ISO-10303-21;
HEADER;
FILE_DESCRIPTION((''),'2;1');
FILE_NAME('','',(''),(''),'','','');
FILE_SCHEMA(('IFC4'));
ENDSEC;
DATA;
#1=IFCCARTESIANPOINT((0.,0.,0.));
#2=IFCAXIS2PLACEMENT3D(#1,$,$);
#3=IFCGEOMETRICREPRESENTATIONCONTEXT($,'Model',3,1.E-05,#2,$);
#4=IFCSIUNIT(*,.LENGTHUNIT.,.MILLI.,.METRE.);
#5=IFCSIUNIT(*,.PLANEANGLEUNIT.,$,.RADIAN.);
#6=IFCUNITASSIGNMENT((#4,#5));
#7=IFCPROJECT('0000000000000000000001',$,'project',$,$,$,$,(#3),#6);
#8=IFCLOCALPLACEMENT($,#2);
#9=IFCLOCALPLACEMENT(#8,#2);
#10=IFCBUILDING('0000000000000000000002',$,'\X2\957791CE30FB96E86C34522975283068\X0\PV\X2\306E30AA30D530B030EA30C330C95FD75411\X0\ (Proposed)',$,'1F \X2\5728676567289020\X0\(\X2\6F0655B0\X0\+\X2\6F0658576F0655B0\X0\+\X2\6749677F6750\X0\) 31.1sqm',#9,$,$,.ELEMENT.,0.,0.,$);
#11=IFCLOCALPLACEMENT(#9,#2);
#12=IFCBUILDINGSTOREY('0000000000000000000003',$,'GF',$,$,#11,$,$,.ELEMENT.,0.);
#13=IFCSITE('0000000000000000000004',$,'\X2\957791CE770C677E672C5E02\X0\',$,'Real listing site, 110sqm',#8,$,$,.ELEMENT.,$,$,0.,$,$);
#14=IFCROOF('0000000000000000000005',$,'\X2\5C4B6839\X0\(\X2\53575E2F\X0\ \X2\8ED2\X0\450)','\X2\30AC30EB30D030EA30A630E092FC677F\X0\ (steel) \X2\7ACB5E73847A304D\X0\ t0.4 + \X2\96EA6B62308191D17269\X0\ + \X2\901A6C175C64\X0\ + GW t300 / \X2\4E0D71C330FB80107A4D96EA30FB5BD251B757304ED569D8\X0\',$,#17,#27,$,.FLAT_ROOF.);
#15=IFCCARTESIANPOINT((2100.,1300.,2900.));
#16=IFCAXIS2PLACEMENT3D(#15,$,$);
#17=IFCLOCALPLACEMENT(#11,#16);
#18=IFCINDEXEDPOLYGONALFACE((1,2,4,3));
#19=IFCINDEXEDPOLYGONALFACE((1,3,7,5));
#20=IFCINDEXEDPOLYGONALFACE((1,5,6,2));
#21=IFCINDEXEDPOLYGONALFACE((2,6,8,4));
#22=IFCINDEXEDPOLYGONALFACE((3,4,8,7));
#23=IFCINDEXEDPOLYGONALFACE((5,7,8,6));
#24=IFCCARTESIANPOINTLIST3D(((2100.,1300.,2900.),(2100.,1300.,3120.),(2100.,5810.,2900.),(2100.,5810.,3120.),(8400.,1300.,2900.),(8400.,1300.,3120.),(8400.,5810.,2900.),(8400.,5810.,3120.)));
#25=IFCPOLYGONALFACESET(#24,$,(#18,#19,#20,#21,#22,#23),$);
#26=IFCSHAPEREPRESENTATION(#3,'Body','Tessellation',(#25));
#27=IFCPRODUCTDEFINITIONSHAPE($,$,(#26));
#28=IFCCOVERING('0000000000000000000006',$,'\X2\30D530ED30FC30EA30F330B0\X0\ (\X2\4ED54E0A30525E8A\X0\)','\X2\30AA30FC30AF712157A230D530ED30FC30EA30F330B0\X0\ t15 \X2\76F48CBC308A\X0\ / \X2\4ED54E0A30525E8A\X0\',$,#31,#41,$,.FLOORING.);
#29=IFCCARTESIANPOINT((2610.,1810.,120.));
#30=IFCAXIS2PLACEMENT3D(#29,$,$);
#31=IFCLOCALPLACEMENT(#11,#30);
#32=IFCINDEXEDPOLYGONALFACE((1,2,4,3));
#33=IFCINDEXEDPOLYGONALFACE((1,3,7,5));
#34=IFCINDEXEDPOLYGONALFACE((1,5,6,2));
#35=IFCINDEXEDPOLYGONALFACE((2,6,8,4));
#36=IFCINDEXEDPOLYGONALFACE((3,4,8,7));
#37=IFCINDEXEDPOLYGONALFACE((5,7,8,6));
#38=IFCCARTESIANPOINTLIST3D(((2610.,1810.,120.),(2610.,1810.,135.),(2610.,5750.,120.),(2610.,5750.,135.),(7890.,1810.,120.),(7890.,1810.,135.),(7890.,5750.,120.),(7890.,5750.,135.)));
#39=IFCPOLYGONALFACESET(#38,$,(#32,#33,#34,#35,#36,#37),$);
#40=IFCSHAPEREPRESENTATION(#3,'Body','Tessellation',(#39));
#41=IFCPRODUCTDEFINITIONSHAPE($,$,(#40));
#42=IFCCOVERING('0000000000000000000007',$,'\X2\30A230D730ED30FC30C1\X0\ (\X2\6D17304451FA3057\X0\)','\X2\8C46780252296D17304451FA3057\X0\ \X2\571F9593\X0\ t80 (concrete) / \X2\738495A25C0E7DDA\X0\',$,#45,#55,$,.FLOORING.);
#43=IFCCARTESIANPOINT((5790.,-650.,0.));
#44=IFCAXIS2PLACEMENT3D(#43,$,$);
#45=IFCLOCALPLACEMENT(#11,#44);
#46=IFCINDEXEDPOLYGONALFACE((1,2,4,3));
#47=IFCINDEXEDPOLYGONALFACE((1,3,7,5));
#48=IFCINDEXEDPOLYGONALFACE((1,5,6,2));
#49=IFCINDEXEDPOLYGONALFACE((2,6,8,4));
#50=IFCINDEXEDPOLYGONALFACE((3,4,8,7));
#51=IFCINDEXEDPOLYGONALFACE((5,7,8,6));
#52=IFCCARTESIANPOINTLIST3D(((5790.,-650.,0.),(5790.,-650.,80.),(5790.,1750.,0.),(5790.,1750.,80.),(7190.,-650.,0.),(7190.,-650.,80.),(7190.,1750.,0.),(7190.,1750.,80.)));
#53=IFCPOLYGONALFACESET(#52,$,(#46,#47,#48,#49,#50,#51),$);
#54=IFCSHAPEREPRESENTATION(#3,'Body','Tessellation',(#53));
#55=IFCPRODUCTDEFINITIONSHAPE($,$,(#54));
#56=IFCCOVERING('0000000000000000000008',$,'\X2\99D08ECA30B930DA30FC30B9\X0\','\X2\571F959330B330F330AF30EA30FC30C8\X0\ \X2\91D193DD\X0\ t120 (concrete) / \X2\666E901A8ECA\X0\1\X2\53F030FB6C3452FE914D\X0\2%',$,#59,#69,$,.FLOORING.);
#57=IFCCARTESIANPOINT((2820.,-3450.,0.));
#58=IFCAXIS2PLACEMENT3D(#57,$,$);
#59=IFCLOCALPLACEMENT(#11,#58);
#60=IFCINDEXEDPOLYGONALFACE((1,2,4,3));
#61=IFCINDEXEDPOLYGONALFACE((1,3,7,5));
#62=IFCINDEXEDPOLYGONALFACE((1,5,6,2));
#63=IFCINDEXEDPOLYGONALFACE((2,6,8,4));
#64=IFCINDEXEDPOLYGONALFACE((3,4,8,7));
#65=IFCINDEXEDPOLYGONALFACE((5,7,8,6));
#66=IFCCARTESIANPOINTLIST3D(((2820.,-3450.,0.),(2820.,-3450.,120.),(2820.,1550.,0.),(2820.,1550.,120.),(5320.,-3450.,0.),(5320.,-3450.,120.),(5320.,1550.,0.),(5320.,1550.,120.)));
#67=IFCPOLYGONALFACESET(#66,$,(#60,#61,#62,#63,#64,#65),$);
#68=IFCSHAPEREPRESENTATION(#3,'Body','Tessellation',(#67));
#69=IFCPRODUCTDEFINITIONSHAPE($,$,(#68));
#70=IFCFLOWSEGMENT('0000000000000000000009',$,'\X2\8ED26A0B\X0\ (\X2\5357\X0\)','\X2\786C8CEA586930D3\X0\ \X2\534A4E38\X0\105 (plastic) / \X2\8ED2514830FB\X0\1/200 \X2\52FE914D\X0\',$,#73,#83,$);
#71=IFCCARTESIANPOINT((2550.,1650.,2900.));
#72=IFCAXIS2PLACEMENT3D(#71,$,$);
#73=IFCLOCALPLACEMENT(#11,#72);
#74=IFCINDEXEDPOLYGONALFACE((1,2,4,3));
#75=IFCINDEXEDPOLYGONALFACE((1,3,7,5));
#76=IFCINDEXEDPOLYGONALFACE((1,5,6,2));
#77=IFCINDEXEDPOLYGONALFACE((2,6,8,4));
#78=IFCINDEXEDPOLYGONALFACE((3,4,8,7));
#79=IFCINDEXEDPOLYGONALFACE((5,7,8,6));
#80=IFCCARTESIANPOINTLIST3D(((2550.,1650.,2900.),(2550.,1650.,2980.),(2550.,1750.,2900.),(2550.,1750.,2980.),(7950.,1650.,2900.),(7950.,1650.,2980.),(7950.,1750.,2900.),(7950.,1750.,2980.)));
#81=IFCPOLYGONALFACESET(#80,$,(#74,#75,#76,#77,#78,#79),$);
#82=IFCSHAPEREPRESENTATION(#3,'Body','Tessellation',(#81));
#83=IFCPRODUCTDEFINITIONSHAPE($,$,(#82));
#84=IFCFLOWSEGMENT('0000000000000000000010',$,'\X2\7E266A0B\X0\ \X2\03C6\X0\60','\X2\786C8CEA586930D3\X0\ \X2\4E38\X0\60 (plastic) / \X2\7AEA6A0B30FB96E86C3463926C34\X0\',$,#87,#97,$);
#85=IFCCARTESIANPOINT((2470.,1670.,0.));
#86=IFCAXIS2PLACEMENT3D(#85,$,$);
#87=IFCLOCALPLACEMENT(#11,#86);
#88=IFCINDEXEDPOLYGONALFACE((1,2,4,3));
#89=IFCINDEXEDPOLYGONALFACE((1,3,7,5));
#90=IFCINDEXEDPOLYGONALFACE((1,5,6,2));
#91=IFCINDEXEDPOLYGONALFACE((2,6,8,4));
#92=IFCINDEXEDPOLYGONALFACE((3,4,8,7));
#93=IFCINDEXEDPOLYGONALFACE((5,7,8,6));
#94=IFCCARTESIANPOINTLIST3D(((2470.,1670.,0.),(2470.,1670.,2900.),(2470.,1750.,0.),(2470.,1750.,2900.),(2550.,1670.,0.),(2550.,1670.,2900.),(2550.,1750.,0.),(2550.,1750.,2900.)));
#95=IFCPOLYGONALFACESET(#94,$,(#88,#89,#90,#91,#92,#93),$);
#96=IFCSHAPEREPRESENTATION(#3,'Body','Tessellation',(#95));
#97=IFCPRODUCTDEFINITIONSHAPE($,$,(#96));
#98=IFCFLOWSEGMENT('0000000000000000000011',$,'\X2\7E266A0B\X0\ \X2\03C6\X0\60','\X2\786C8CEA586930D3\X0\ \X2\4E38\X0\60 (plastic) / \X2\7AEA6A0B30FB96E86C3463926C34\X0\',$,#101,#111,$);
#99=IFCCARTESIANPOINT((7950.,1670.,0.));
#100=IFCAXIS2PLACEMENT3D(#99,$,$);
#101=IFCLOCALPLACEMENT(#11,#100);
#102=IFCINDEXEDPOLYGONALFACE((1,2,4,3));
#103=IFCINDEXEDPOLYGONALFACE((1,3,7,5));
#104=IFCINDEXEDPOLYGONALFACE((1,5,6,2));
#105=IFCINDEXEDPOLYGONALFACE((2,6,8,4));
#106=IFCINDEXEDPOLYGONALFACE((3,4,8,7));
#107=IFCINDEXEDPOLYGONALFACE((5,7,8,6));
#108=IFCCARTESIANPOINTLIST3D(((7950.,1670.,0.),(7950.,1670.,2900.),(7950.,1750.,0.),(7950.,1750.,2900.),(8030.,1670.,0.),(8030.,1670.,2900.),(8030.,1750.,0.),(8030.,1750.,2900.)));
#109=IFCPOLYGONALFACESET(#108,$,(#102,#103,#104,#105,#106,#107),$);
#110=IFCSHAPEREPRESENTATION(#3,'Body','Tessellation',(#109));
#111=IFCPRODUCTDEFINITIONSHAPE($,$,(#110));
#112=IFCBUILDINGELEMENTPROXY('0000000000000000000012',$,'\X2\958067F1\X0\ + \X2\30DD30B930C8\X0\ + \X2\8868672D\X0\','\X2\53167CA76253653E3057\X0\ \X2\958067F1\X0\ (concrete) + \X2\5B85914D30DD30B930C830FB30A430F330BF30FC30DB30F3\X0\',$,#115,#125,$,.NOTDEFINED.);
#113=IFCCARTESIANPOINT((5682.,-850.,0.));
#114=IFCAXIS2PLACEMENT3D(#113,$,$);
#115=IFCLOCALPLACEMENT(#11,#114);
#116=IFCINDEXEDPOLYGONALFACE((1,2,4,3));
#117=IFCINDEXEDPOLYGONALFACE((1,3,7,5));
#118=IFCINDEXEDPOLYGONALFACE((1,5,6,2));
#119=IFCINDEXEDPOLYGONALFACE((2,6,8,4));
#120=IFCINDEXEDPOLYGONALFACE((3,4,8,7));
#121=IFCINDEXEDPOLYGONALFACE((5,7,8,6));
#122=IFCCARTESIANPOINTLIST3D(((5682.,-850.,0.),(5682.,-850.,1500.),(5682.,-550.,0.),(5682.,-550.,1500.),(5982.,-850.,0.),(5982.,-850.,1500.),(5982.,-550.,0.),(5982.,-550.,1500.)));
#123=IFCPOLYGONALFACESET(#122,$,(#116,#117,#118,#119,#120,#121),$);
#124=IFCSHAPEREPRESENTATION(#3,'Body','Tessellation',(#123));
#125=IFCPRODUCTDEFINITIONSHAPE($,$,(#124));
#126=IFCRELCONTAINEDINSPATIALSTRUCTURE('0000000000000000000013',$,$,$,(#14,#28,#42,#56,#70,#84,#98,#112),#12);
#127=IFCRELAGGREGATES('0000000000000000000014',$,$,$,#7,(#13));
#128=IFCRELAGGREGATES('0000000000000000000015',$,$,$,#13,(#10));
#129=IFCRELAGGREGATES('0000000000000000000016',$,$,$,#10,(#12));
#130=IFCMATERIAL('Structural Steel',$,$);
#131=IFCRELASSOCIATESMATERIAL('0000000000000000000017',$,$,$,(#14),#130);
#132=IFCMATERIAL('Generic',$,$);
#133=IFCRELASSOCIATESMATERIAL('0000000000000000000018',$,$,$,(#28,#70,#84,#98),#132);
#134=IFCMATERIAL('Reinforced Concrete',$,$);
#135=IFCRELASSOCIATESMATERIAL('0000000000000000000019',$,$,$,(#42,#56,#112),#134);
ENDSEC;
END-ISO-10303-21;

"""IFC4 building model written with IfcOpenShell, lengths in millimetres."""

from ifc_helpers import new_model, si_unit, frame, frame_2d, origin, place, context, project, spatial, rectangle, extrude, material, element, save


model = new_model("IFC4")

# Units and contexts
model_context = context("Model", 3, precision=1e-05, world=origin())
ifc_project = project(units=[si_unit("LENGTHUNIT", "METRE", prefix="MILLI"), si_unit("PLANEANGLEUNIT", "RADIAN")], contexts=[model_context])

# Site, building, storey
site_placement = place(None, origin())
site = spatial("IfcSite", under=ifc_project, at=site_placement, Name="長野県松本市", ObjectType="Real listing site, 110sqm", CompositionType="ELEMENT", RefElevation=0.0)
building_placement = place(site_placement, origin())
building = spatial("IfcBuilding", under=site, at=building_placement, Name="長野・雨水利用とPVのオフグリッド志向 (Proposed)", ObjectType="1F 在来木造(漆喰+漆塗漆喰+杉板材) 31.1sqm", CompositionType="ELEMENT", ElevationOfRefHeight=0.0, ElevationOfTerrain=0.0)
storey_placement = place(building_placement, origin())
storey = spatial("IfcBuildingStorey", under=building, at=storey_placement, Name="GF", CompositionType="ELEMENT", Elevation=0.0)

# Shared definitions
ifc_material_1 = material(Name="Reinforced Concrete")

# Roof
ifc_material_2 = material(Name="Structural Steel")
roof_placement = place(storey_placement, frame((2100.0, 1300.0, 2900.0)))
element("IfcRoof", 1, at=roof_placement, inside=storey, material=ifc_material_2, Name="屋根(南帯 軒450)", Description="ガルバリウム鋼板 (steel) 立平葺き t0.4 + 雪止め金物 + 通気層 + GW t300 / 不燃・耐積雪・寒冷地仕様", PredefinedType="FLAT_ROOF", context=model_context, shape_type="SweptSolid", body=[
    extrude(rectangle(XDim=6300.0, YDim=4510.0, at=frame_2d((3150.0, 2255.0))), frame((2100.0, 1300.0, 2900.0)), (0.0, 0.0, 1.0), 220.0),
])

# Coverings
ifc_material_3 = material(Name="Generic")
covering_1_placement = place(storey_placement, frame((2610.0, 1810.0, 120.0)))
element("IfcCovering", 2, at=covering_1_placement, inside=storey, material=ifc_material_3, Name="フローリング (仕上げ床)", Description="オーク無垢フローリング t15 直貼り / 仕上げ床", PredefinedType="FLOORING", context=model_context, shape_type="SweptSolid", body=[
    extrude(rectangle(XDim=5280.0, YDim=3940.0, at=frame_2d((2640.0, 1970.0))), frame((2610.0, 1810.0, 120.0)), (0.0, 0.0, 1.0), 15.0),
])
covering_2_placement = place(storey_placement, frame((5790.0, -650.0, 0.0)))
element("IfcCovering", 3, at=covering_2_placement, inside=storey, material=ifc_material_1, Name="アプローチ (洗い出し)", Description="豆砂利洗い出し 土間 t80 (concrete) / 玄関導線", PredefinedType="FLOORING", context=model_context, shape_type="SweptSolid", body=[
    extrude(rectangle(XDim=1400.0, YDim=2400.0, at=frame_2d((700.0, 1200.0))), frame((5790.0, -650.0, 0.0)), (0.0, 0.0, 1.0), 80.0),
])
covering_3_placement = place(storey_placement, frame((2820.0, -3450.0, 0.0)))
element("IfcCovering", 4, at=covering_3_placement, inside=storey, material=ifc_material_1, Name="駐車スペース", Description="土間コンクリート 金鏝 t120 (concrete) / 普通車1台・水勾配2%", PredefinedType="FLOORING", context=model_context, shape_type="SweptSolid", body=[
    extrude(rectangle(XDim=2500.0, YDim=5000.0, at=frame_2d((1250.0, 2500.0))), frame((2820.0, -3450.0, 0.0)), (0.0, 0.0, 1.0), 120.0),
])

# Flow segments
flow_segment_1_placement = place(storey_placement, frame((2550.0, 1650.0, 2900.0)))
element("IfcFlowSegment", 5, at=flow_segment_1_placement, inside=storey, material=ifc_material_3, Name="軒樋 (南)", Description="硬質塩ビ 半丸105 (plastic) / 軒先・1/200 勾配", context=model_context, shape_type="SweptSolid", body=[
    extrude(rectangle(XDim=5400.0, YDim=100.0, at=frame_2d((2700.0, 50.0))), frame((2550.0, 1650.0, 2900.0)), (0.0, 0.0, 1.0), 80.0),
])
flow_segment_2_placement = place(storey_placement, frame((2470.0, 1670.0, 0.0)))
element("IfcFlowSegment", 6, at=flow_segment_2_placement, inside=storey, material=ifc_material_3, Name="縦樋 φ60", Description="硬質塩ビ 丸60 (plastic) / 竪樋・雨水排水", context=model_context, shape_type="SweptSolid", body=[
    extrude(rectangle(XDim=80.0, YDim=80.0, at=frame_2d((40.0, 40.0))), frame((2470.0, 1670.0, 0.0)), (0.0, 0.0, 1.0), 2900.0),
])
flow_segment_3_placement = place(storey_placement, frame((7950.0, 1670.0, 0.0)))
element("IfcFlowSegment", 7, at=flow_segment_3_placement, inside=storey, material=ifc_material_3, Name="縦樋 φ60", Description="硬質塩ビ 丸60 (plastic) / 竪樋・雨水排水", context=model_context, shape_type="SweptSolid", body=[
    extrude(rectangle(XDim=80.0, YDim=80.0, at=frame_2d((40.0, 40.0))), frame((7950.0, 1670.0, 0.0)), (0.0, 0.0, 1.0), 2900.0),
])

# Building element proxy
proxy_placement = place(storey_placement, frame((5682.0, -850.0, 0.0)))
element("IfcBuildingElementProxy", 8, at=proxy_placement, inside=storey, material=ifc_material_1, Name="門柱 + ポスト + 表札", Description="化粧打放し 門柱 (concrete) + 宅配ポスト・インターホン", PredefinedType="NOTDEFINED", context=model_context, shape_type="SweptSolid", body=[
    extrude(rectangle(XDim=300.0, YDim=300.0, at=frame_2d((150.0, 150.0))), frame((5682.0, -850.0, 0.0)), (0.0, 0.0, 1.0), 1500.0),
])

save(model, "model.ifc")
